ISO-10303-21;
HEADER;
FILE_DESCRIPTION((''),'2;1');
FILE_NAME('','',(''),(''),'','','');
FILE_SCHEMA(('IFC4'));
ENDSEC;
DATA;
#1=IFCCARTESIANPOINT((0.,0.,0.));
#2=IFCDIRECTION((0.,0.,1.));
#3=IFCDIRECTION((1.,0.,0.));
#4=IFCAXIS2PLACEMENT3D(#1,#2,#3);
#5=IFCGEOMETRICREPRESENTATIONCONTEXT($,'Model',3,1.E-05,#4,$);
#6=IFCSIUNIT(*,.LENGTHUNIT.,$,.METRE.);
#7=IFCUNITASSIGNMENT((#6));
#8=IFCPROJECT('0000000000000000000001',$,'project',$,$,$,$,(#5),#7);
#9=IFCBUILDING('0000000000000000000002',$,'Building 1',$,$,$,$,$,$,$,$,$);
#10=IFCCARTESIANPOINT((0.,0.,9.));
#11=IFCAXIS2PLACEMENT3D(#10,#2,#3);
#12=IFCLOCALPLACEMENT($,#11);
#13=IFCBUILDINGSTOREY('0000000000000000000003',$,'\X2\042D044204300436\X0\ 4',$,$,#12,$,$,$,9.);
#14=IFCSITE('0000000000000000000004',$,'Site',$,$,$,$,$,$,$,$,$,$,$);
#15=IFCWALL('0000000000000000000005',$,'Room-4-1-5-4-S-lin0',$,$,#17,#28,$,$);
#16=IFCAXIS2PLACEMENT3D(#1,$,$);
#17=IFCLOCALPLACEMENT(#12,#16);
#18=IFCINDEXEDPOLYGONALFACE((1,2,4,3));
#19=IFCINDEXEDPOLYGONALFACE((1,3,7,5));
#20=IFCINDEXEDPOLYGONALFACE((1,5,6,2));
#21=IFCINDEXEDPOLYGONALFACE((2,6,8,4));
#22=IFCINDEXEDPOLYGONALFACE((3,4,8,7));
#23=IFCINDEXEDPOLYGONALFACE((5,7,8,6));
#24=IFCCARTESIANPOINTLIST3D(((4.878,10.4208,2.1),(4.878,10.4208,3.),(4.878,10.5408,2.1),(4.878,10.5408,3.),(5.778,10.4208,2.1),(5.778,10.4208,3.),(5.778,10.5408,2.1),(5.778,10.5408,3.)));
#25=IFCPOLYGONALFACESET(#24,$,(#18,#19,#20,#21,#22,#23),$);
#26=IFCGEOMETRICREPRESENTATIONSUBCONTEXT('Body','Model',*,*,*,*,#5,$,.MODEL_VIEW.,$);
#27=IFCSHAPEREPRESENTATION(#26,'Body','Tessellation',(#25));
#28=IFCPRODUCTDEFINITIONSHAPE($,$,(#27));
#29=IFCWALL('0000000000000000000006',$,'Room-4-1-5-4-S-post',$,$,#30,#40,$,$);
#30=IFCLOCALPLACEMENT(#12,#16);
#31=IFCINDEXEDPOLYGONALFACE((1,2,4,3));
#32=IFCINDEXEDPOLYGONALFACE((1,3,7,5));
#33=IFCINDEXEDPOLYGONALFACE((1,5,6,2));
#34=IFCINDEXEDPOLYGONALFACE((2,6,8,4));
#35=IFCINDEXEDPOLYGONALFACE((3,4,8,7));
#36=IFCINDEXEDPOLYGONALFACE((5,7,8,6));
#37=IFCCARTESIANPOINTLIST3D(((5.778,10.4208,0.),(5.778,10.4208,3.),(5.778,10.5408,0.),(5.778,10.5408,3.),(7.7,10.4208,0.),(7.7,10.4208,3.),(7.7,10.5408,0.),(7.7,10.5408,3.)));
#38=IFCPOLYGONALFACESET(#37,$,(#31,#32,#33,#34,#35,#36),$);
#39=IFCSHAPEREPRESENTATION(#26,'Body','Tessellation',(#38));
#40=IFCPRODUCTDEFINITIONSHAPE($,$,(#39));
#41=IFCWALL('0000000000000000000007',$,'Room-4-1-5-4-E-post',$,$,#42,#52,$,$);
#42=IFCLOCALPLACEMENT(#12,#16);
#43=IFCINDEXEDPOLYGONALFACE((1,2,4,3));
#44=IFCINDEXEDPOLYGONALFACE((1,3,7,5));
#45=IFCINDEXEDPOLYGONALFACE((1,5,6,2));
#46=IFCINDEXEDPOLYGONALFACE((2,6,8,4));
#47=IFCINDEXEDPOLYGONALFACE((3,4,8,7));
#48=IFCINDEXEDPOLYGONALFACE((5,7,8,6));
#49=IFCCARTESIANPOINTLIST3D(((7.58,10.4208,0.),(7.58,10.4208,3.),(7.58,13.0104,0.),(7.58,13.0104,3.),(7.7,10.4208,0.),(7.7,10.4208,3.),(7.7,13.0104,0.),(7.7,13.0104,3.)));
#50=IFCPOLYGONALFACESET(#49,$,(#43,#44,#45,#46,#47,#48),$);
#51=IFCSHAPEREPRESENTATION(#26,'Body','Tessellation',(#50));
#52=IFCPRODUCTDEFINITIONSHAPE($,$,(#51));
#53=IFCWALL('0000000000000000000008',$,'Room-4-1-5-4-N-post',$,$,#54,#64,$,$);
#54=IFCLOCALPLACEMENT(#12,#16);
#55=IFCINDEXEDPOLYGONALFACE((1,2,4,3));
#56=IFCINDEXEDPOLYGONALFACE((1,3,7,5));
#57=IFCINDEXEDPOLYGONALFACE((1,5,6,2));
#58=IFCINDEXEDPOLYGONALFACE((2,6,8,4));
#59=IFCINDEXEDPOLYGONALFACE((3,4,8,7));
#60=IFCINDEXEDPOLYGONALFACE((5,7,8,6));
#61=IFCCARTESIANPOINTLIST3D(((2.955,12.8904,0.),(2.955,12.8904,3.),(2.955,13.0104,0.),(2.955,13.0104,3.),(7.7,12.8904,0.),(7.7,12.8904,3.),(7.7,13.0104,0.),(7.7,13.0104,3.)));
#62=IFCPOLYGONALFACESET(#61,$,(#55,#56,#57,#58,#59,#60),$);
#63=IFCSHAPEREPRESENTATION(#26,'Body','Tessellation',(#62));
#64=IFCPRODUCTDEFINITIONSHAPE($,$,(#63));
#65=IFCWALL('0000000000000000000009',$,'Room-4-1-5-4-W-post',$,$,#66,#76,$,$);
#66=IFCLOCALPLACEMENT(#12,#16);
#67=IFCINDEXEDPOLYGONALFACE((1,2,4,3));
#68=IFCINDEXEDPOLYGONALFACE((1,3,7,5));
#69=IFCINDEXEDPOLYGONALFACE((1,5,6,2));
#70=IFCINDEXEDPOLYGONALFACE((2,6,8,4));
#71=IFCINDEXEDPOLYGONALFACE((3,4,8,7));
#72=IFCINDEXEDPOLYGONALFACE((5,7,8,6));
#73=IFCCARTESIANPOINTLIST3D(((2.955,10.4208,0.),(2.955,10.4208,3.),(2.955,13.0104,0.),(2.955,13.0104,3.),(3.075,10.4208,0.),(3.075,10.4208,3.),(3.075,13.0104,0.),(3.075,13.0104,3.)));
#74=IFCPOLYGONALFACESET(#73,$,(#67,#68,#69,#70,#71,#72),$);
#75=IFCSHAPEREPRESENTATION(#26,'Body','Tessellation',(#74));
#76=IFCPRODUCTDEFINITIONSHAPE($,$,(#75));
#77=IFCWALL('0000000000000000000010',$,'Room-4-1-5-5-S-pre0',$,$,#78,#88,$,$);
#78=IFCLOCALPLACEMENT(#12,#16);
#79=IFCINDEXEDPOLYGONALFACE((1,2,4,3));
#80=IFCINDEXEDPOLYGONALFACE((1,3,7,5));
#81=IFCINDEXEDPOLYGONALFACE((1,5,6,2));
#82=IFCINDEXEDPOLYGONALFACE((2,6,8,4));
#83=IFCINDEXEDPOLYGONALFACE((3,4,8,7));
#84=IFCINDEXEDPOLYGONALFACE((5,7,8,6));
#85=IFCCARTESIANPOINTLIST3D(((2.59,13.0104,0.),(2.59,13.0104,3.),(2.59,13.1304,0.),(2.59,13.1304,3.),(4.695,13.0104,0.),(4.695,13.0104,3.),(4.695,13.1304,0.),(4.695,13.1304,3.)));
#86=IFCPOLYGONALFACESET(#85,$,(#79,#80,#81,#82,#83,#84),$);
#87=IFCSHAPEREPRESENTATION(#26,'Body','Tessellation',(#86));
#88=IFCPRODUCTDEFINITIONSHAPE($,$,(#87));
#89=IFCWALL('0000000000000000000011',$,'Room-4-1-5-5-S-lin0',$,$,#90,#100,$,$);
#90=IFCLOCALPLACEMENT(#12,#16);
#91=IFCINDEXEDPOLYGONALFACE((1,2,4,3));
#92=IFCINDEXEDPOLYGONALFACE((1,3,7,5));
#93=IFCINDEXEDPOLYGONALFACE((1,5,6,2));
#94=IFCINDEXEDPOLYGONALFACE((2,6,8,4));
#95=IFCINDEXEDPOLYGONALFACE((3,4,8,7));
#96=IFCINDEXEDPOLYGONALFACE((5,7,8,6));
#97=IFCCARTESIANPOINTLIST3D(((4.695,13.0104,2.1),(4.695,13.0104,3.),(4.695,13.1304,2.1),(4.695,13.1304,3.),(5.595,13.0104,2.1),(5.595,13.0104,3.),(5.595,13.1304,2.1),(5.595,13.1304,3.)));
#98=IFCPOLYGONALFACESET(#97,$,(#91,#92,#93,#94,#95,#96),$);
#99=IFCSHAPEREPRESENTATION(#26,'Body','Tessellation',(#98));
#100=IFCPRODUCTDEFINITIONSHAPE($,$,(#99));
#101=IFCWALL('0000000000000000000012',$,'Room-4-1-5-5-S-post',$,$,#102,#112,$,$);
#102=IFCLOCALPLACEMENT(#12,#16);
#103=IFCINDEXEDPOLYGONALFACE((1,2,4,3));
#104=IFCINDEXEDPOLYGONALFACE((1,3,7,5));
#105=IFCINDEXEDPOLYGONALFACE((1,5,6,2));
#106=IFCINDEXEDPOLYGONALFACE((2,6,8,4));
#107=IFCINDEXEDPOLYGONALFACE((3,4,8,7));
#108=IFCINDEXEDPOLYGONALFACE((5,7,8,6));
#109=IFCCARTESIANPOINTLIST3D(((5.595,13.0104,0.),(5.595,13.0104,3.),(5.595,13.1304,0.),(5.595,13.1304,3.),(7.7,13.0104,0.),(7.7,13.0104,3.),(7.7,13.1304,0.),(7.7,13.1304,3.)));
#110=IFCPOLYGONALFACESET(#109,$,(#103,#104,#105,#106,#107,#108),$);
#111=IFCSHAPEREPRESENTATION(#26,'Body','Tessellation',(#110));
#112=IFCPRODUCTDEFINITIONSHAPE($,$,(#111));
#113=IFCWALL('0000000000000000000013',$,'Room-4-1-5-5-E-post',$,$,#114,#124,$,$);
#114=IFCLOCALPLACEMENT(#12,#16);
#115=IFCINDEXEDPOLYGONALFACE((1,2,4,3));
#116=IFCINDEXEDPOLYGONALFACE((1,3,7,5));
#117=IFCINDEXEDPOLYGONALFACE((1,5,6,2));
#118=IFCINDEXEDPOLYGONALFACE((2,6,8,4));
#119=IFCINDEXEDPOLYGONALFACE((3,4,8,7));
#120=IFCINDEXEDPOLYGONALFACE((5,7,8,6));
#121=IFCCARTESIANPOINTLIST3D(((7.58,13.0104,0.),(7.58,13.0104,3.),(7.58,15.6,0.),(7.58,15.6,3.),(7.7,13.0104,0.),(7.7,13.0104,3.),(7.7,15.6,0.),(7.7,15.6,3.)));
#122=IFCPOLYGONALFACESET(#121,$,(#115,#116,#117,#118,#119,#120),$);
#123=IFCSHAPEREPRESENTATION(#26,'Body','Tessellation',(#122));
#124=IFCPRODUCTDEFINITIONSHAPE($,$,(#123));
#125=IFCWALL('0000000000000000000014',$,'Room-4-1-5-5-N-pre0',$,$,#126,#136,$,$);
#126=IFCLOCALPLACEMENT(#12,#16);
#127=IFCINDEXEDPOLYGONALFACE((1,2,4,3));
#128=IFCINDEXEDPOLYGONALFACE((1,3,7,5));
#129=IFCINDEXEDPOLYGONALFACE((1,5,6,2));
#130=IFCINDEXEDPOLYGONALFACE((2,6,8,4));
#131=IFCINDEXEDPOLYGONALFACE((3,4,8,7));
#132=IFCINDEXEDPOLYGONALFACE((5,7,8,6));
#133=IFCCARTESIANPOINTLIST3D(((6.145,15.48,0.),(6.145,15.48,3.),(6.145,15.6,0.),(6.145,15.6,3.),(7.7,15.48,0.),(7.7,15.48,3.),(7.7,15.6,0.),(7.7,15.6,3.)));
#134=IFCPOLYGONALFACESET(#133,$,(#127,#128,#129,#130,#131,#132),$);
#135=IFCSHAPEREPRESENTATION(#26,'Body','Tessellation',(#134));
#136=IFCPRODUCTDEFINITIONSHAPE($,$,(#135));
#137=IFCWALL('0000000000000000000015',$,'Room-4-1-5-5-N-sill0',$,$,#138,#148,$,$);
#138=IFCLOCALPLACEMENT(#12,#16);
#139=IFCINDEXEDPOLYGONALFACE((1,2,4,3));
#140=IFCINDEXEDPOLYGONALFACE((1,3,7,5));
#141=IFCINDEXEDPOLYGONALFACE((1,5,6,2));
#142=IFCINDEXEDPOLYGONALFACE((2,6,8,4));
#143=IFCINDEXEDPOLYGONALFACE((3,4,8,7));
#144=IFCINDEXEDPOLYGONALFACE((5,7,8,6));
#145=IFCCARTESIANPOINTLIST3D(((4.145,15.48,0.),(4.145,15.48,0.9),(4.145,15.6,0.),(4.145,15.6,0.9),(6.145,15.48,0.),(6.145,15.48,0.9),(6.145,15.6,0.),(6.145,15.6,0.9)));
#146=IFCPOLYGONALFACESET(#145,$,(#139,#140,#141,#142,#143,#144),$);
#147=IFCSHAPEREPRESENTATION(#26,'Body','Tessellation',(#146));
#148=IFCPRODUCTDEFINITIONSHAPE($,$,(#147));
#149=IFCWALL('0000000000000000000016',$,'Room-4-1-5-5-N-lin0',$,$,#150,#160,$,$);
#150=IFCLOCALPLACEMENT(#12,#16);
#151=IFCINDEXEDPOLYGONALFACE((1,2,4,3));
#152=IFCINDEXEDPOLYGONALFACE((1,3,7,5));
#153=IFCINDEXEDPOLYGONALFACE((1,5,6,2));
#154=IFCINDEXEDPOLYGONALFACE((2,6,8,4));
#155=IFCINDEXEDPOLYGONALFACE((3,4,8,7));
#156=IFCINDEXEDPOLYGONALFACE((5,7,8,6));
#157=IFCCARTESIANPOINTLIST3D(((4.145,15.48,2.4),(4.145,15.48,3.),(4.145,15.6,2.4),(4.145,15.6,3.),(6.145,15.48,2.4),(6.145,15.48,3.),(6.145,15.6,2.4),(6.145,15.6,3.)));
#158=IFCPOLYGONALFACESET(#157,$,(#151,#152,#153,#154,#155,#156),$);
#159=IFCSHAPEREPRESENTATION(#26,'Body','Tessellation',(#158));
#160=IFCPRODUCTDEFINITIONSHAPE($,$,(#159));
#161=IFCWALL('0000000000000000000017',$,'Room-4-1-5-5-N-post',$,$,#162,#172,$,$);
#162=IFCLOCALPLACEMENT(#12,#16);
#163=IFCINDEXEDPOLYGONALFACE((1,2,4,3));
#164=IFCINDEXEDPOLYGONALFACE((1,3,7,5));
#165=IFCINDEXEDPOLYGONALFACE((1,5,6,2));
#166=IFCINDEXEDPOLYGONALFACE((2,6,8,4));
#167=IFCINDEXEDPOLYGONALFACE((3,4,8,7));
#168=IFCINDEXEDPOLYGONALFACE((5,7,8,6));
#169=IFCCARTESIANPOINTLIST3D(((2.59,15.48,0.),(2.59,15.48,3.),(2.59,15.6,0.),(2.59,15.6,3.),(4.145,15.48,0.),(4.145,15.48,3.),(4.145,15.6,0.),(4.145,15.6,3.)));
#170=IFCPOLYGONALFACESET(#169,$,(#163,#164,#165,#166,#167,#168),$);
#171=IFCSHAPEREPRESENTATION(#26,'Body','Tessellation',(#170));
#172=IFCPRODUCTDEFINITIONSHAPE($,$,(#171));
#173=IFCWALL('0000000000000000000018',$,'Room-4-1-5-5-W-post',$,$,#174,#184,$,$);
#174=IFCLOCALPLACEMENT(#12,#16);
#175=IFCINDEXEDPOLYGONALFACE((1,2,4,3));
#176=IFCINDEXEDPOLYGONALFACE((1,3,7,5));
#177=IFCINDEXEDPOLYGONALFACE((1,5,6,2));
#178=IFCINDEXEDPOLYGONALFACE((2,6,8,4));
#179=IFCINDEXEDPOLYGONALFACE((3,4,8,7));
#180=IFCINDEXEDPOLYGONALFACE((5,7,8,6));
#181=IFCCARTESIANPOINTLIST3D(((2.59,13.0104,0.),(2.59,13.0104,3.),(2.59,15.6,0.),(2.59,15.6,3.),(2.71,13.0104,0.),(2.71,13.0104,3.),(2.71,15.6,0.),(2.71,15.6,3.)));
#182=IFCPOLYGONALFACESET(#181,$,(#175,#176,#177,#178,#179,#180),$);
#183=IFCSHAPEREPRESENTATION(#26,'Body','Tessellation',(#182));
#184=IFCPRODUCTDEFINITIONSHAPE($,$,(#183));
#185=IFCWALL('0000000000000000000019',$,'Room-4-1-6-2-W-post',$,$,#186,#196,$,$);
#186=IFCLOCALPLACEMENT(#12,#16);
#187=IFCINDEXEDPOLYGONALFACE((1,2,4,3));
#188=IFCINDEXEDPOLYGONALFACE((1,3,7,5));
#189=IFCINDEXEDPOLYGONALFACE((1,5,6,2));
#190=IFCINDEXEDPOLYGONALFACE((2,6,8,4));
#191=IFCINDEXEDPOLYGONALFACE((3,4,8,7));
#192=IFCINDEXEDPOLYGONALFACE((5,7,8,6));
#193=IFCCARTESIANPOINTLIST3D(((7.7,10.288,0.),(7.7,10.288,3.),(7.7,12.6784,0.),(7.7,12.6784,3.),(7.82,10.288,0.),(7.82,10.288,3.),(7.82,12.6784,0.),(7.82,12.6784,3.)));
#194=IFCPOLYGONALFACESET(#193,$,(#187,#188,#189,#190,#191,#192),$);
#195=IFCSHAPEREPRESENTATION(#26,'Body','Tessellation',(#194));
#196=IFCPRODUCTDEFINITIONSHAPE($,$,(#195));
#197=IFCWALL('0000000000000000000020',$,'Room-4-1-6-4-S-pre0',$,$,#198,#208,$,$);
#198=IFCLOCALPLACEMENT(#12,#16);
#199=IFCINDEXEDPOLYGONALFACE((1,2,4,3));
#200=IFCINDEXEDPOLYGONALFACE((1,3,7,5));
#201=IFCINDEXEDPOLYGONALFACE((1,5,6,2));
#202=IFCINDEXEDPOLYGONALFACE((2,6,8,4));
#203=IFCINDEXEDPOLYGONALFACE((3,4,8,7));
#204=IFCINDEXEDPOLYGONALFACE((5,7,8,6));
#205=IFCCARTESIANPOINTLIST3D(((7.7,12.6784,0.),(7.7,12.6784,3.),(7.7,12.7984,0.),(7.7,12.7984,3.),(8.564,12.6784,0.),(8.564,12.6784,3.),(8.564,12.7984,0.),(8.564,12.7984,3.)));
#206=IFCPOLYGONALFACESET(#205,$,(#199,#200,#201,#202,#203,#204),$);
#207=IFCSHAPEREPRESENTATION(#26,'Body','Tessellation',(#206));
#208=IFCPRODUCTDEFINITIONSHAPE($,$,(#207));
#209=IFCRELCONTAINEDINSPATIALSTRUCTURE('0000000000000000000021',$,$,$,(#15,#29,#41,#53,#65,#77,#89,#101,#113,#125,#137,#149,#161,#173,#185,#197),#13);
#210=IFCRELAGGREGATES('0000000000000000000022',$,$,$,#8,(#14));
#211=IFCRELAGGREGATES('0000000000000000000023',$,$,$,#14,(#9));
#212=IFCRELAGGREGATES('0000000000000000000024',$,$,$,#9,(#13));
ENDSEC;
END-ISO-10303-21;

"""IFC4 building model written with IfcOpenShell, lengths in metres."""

from ifc_helpers import new_model, si_unit, frame, origin_with_axes, place, context, subcontext, project, spatial, indexed_curve, outline, extrude, element, save


model = new_model("IFC4")

# Units and contexts
model_context = context("Model", 3, precision=1e-05, world=origin_with_axes())
body_context = subcontext(model_context, "Body", "Model", "MODEL_VIEW")
ifc_project = project(units=[si_unit("LENGTHUNIT", "METRE")], contexts=[model_context])

# Site, building, storey
site = spatial("IfcSite", under=ifc_project, Name="Site")
building = spatial("IfcBuilding", under=site, Name="Building 1")
storey_placement = place(None, frame((0.0, 0.0, 9.0), z_axis=(0.0, 0.0, 1.0), x_axis=(1.0, 0.0, 0.0)))
storey = spatial("IfcBuildingStorey", under=building, at=storey_placement, Name="Этаж 4", Elevation=9.0)

# Walls
wall_1_placement = place(storey_placement, frame((4.878, 10.4208, 2.1), z_axis=(0.0, 0.0, 1.0), x_axis=(1.0, 0.0, 0.0)))
element("IfcWall", 1, at=wall_1_placement, inside=storey, Name="Room-4-1-5-4-S-lin0", context=body_context, shape_type="SweptSolid", body=[
    extrude(outline(indexed_curve([(0.0, 0.0), (0.0, 0.12), (0.9, 0.12), (0.9, 0.0), (0.0, 0.0)], self_intersect=False)), origin_with_axes(), (0.0, 0.0, 1.0), 0.9),
])
wall_2_placement = place(storey_placement, frame((5.778, 10.4208, 0.0), z_axis=(0.0, 0.0, 1.0), x_axis=(1.0, 0.0, 0.0)))
element("IfcWall", 2, at=wall_2_placement, inside=storey, Name="Room-4-1-5-4-S-post", context=body_context, shape_type="SweptSolid", body=[
    extrude(outline(indexed_curve([(0.0, 0.0), (0.0, 0.12), (1.922, 0.12), (1.922, 0.0), (0.0, 0.0)], self_intersect=False)), origin_with_axes(), (0.0, 0.0, 1.0), 3.0),
])
wall_3_placement = place(storey_placement, frame((7.7, 10.4208, 0.0), z_axis=(0.0, 0.0, 1.0), x_axis=(0.0, 1.0, 0.0)))
element("IfcWall", 3, at=wall_3_placement, inside=storey, Name="Room-4-1-5-4-E-post", context=body_context, shape_type="SweptSolid", body=[
    extrude(outline(indexed_curve([(0.0, 0.0), (0.0, 0.12), (2.5896, 0.12), (2.5896, 0.0), (0.0, 0.0)], self_intersect=False)), origin_with_axes(), (0.0, 0.0, 1.0), 3.0),
])
wall_4_placement = place(storey_placement, frame((7.7, 13.0104, 0.0), z_axis=(0.0, 0.0, 1.0), x_axis=(-1.0, 0.0, 0.0)))
element("IfcWall", 4, at=wall_4_placement, inside=storey, Name="Room-4-1-5-4-N-post", context=body_context, shape_type="SweptSolid", body=[
    extrude(outline(indexed_curve([(0.0, 0.0), (0.0, 0.12), (4.745, 0.12), (4.745, 0.0), (0.0, 0.0)], self_intersect=False)), origin_with_axes(), (0.0, 0.0, 1.0), 3.0),
])
wall_5_placement = place(storey_placement, frame((2.955, 13.0104, 0.0), z_axis=(0.0, 0.0, 1.0), x_axis=(0.0, -1.0, 0.0)))
element("IfcWall", 5, at=wall_5_placement, inside=storey, Name="Room-4-1-5-4-W-post", context=body_context, shape_type="SweptSolid", body=[
    extrude(outline(indexed_curve([(0.0, 0.0), (0.0, 0.12), (2.5896, 0.12), (2.5896, 0.0), (0.0, 0.0)], self_intersect=False)), origin_with_axes(), (0.0, 0.0, 1.0), 3.0),
])
wall_6_placement = place(storey_placement, frame((2.59, 13.0104, 0.0), z_axis=(0.0, 0.0, 1.0), x_axis=(1.0, 0.0, 0.0)))
element("IfcWall", 6, at=wall_6_placement, inside=storey, Name="Room-4-1-5-5-S-pre0", context=body_context, shape_type="SweptSolid", body=[
    extrude(outline(indexed_curve([(0.0, 0.0), (0.0, 0.12), (2.105, 0.12), (2.105, 0.0), (0.0, 0.0)], self_intersect=False)), origin_with_axes(), (0.0, 0.0, 1.0), 3.0),
])
wall_7_placement = place(storey_placement, frame((4.695, 13.0104, 2.1), z_axis=(0.0, 0.0, 1.0), x_axis=(1.0, 0.0, 0.0)))
element("IfcWall", 7, at=wall_7_placement, inside=storey, Name="Room-4-1-5-5-S-lin0", context=body_context, shape_type="SweptSolid", body=[
    extrude(outline(indexed_curve([(0.0, 0.0), (0.0, 0.12), (0.9, 0.12), (0.9, 0.0), (0.0, 0.0)], self_intersect=False)), origin_with_axes(), (0.0, 0.0, 1.0), 0.9),
])
wall_8_placement = place(storey_placement, frame((5.595, 13.0104, 0.0), z_axis=(0.0, 0.0, 1.0), x_axis=(1.0, 0.0, 0.0)))
element("IfcWall", 8, at=wall_8_placement, inside=storey, Name="Room-4-1-5-5-S-post", context=body_context, shape_type="SweptSolid", body=[
    extrude(outline(indexed_curve([(0.0, 0.0), (0.0, 0.12), (2.105, 0.12), (2.105, 0.0), (0.0, 0.0)], self_intersect=False)), origin_with_axes(), (0.0, 0.0, 1.0), 3.0),
])
wall_9_placement = place(storey_placement, frame((7.7, 13.0104, 0.0), z_axis=(0.0, 0.0, 1.0), x_axis=(0.0, 1.0, 0.0)))
element("IfcWall", 9, at=wall_9_placement, inside=storey, Name="Room-4-1-5-5-E-post", context=body_context, shape_type="SweptSolid", body=[
    extrude(outline(indexed_curve([(0.0, 0.0), (0.0, 0.12), (2.5896, 0.12), (2.5896, 0.0), (0.0, 0.0)], self_intersect=False)), origin_with_axes(), (0.0, 0.0, 1.0), 3.0),
])
wall_10_placement = place(storey_placement, frame((7.7, 15.6, 0.0), z_axis=(0.0, 0.0, 1.0), x_axis=(-1.0, 0.0, 0.0)))
element("IfcWall", 10, at=wall_10_placement, inside=storey, Name="Room-4-1-5-5-N-pre0", context=body_context, shape_type="SweptSolid", body=[
    extrude(outline(indexed_curve([(0.0, 0.0), (0.0, 0.12), (1.555, 0.12), (1.555, 0.0), (0.0, 0.0)], self_intersect=False)), origin_with_axes(), (0.0, 0.0, 1.0), 3.0),
])
wall_11_placement = place(storey_placement, frame((6.145, 15.6, 0.0), z_axis=(0.0, 0.0, 1.0), x_axis=(-1.0, 0.0, 0.0)))
element("IfcWall", 11, at=wall_11_placement, inside=storey, Name="Room-4-1-5-5-N-sill0", context=body_context, shape_type="SweptSolid", body=[
    extrude(outline(indexed_curve([(0.0, 0.0), (0.0, 0.12), (2.0, 0.12), (2.0, 0.0), (0.0, 0.0)], self_intersect=False)), origin_with_axes(), (0.0, 0.0, 1.0), 0.9),
])
wall_12_placement = place(storey_placement, frame((6.145, 15.6, 2.4), z_axis=(0.0, 0.0, 1.0), x_axis=(-1.0, 0.0, 0.0)))
element("IfcWall", 12, at=wall_12_placement, inside=storey, Name="Room-4-1-5-5-N-lin0", context=body_context, shape_type="SweptSolid", body=[
    extrude(outline(indexed_curve([(0.0, 0.0), (0.0, 0.12), (2.0, 0.12), (2.0, 0.0), (0.0, 0.0)], self_intersect=False)), origin_with_axes(), (0.0, 0.0, 1.0), 0.6),
])
wall_13_placement = place(storey_placement, frame((4.145, 15.6, 0.0), z_axis=(0.0, 0.0, 1.0), x_axis=(-1.0, 0.0, 0.0)))
element("IfcWall", 13, at=wall_13_placement, inside=storey, Name="Room-4-1-5-5-N-post", context=body_context, shape_type="SweptSolid", body=[
    extrude(outline(indexed_curve([(0.0, 0.0), (0.0, 0.12), (1.555, 0.12), (1.555, 0.0), (0.0, 0.0)], self_intersect=False)), origin_with_axes(), (0.0, 0.0, 1.0), 3.0),
])
wall_14_placement = place(storey_placement, frame((2.59, 15.6, 0.0), z_axis=(0.0, 0.0, 1.0), x_axis=(0.0, -1.0, 0.0)))
element("IfcWall", 14, at=wall_14_placement, inside=storey, Name="Room-4-1-5-5-W-post", context=body_context, shape_type="SweptSolid", body=[
    extrude(outline(indexed_curve([(0.0, 0.0), (0.0, 0.12), (2.5896, 0.12), (2.5896, 0.0), (0.0, 0.0)], self_intersect=False)), origin_with_axes(), (0.0, 0.0, 1.0), 3.0),
])
wall_15_placement = place(storey_placement, frame((7.7, 12.6784, 0.0), z_axis=(0.0, 0.0, 1.0), x_axis=(0.0, -1.0, 0.0)))
element("IfcWall", 15, at=wall_15_placement, inside=storey, Name="Room-4-1-6-2-W-post", context=body_context, shape_type="SweptSolid", body=[
    extrude(outline(indexed_curve([(0.0, 0.0), (0.0, 0.12), (2.3904, 0.12), (2.3904, 0.0), (0.0, 0.0)], self_intersect=False)), origin_with_axes(), (0.0, 0.0, 1.0), 3.0),
])
wall_16_placement = place(storey_placement, frame((7.7, 12.6784, 0.0), z_axis=(0.0, 0.0, 1.0), x_axis=(1.0, 0.0, 0.0)))
element("IfcWall", 16, at=wall_16_placement, inside=storey, Name="Room-4-1-6-4-S-pre0", context=body_context, shape_type="SweptSolid", body=[
    extrude(outline(indexed_curve([(0.0, 0.0), (0.0, 0.12), (0.864, 0.12), (0.864, 0.0), (0.0, 0.0)], self_intersect=False)), origin_with_axes(), (0.0, 0.0, 1.0), 3.0),
])

save(model, "model.ifc")
